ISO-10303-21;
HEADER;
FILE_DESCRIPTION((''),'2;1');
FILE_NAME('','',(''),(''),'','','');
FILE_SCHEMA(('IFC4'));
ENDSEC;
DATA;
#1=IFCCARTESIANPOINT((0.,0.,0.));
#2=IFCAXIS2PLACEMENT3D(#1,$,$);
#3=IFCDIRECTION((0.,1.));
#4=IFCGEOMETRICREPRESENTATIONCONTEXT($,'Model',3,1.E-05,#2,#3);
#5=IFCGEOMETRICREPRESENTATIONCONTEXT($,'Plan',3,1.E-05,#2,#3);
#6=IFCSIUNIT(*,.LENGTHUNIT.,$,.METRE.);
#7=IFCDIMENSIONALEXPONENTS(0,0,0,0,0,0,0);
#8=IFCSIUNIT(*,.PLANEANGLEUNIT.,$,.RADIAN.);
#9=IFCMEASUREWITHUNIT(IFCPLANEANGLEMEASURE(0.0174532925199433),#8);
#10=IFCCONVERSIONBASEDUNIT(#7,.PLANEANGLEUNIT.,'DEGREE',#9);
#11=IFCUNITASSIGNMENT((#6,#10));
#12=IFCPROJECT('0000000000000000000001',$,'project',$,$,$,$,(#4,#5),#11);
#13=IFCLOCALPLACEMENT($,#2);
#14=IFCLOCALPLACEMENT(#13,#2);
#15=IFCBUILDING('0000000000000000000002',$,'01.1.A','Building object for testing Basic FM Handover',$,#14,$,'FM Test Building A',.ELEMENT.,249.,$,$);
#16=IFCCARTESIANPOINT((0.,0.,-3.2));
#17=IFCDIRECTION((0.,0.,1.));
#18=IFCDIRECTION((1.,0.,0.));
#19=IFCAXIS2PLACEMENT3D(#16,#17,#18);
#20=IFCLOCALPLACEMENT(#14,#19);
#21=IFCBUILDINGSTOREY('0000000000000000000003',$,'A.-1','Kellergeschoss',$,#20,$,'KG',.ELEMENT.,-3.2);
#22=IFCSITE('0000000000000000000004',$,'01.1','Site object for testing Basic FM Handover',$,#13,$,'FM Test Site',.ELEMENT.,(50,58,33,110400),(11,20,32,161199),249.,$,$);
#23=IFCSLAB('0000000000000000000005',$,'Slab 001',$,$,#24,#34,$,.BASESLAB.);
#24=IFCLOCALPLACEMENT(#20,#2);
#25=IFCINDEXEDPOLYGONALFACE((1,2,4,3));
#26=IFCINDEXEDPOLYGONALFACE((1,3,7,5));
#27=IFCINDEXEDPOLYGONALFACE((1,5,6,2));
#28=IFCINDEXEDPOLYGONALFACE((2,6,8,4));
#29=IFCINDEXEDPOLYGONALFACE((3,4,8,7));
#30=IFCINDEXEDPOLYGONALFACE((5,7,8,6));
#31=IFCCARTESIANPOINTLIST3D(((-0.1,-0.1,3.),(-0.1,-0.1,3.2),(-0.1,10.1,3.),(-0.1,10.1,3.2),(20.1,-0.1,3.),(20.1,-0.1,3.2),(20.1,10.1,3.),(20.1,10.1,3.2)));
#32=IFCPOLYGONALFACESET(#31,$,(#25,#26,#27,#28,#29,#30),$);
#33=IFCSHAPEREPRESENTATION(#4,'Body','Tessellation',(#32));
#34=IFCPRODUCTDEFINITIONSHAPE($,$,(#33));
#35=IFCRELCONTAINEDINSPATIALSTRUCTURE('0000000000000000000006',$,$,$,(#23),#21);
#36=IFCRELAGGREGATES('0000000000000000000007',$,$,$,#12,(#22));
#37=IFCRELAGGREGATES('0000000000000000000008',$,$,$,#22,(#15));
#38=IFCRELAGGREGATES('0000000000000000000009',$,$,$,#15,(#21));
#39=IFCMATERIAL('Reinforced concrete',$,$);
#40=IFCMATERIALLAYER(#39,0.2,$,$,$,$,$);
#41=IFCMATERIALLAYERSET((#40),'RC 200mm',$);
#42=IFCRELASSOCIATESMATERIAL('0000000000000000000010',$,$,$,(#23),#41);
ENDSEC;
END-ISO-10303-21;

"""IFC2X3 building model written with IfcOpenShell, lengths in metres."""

from ifc_helpers import new_model, entity, si_unit, converted_unit, direction, frame, origin, place, context, project, spatial, polyline, outline, extrude, material, layer, layer_set, layer_usage, element, save


model = new_model("IFC2X3")

# Units and contexts
model_context = context("Model", 3, precision=1e-05, world=origin(), true_north=direction((0.0, 1.0)))
plan_context = context("Plan", 3, precision=1e-05, world=origin(), true_north=direction((0.0, 1.0)))
ifc_project = project(units=[si_unit("LENGTHUNIT", "METRE"), converted_unit("PLANEANGLEUNIT", "DEGREE", entity("IfcPlaneAngleMeasure", 0.0174532925199433), si_unit("PLANEANGLEUNIT", "RADIAN"), dimensions=[0, 0, 0, 0, 0, 0, 0])], contexts=[model_context, plan_context])

# Site, building, storey
site_placement = place(None, origin())
site = spatial("IfcSite", under=ifc_project, at=site_placement, Name="01.1", Description="Site object for testing Basic FM Handover", LongName="FM Test Site", CompositionType="ELEMENT", RefLatitude=(50, 58, 33, 110400), RefLongitude=(11, 20, 32, 161199), RefElevation=249.0)
building_placement = place(site_placement, origin())
building = spatial("IfcBuilding", under=site, at=building_placement, Name="01.1.A", Description="Building object for testing Basic FM Handover", LongName="FM Test Building A", CompositionType="ELEMENT", ElevationOfRefHeight=249.0)
storey_placement = place(building_placement, frame((0.0, 0.0, -3.2), z_axis=(0.0, 0.0, 1.0), x_axis=(1.0, 0.0, 0.0)))
storey = spatial("IfcBuildingStorey", under=building, at=storey_placement, Name="A.-1", Description="Kellergeschoss", LongName="KG", CompositionType="ELEMENT", Elevation=-3.2)

# Slab
ifc_material = material(Name="Reinforced concrete")
ifc_layer = layer(ifc_material, 0.2)
ifc_layer_set = layer_set([ifc_layer], Name="RC 200mm")
ifc_layer_usage = layer_usage(ifc_layer_set, "AXIS3", "POSITIVE", 0.0)
slab_placement = place(storey_placement, frame((0.0, 0.0, 3.0), z_axis=(0.0, 0.0, 1.0), x_axis=(1.0, 0.0, 0.0)))
element("IfcSlab", 1, at=slab_placement, inside=storey, material=ifc_layer_usage, Name="Slab 001", PredefinedType="BASESLAB", context=model_context, shape_type="SweptSolid", body=[
    extrude(outline(polyline([(-0.1, -0.1), (20.1, -0.1), (20.1, 10.1), (-0.1, 10.1), (-0.1, -0.1)])), origin(), (0.0, 0.0, 1.0), 0.2),
])

save(model, "model.ifc")
